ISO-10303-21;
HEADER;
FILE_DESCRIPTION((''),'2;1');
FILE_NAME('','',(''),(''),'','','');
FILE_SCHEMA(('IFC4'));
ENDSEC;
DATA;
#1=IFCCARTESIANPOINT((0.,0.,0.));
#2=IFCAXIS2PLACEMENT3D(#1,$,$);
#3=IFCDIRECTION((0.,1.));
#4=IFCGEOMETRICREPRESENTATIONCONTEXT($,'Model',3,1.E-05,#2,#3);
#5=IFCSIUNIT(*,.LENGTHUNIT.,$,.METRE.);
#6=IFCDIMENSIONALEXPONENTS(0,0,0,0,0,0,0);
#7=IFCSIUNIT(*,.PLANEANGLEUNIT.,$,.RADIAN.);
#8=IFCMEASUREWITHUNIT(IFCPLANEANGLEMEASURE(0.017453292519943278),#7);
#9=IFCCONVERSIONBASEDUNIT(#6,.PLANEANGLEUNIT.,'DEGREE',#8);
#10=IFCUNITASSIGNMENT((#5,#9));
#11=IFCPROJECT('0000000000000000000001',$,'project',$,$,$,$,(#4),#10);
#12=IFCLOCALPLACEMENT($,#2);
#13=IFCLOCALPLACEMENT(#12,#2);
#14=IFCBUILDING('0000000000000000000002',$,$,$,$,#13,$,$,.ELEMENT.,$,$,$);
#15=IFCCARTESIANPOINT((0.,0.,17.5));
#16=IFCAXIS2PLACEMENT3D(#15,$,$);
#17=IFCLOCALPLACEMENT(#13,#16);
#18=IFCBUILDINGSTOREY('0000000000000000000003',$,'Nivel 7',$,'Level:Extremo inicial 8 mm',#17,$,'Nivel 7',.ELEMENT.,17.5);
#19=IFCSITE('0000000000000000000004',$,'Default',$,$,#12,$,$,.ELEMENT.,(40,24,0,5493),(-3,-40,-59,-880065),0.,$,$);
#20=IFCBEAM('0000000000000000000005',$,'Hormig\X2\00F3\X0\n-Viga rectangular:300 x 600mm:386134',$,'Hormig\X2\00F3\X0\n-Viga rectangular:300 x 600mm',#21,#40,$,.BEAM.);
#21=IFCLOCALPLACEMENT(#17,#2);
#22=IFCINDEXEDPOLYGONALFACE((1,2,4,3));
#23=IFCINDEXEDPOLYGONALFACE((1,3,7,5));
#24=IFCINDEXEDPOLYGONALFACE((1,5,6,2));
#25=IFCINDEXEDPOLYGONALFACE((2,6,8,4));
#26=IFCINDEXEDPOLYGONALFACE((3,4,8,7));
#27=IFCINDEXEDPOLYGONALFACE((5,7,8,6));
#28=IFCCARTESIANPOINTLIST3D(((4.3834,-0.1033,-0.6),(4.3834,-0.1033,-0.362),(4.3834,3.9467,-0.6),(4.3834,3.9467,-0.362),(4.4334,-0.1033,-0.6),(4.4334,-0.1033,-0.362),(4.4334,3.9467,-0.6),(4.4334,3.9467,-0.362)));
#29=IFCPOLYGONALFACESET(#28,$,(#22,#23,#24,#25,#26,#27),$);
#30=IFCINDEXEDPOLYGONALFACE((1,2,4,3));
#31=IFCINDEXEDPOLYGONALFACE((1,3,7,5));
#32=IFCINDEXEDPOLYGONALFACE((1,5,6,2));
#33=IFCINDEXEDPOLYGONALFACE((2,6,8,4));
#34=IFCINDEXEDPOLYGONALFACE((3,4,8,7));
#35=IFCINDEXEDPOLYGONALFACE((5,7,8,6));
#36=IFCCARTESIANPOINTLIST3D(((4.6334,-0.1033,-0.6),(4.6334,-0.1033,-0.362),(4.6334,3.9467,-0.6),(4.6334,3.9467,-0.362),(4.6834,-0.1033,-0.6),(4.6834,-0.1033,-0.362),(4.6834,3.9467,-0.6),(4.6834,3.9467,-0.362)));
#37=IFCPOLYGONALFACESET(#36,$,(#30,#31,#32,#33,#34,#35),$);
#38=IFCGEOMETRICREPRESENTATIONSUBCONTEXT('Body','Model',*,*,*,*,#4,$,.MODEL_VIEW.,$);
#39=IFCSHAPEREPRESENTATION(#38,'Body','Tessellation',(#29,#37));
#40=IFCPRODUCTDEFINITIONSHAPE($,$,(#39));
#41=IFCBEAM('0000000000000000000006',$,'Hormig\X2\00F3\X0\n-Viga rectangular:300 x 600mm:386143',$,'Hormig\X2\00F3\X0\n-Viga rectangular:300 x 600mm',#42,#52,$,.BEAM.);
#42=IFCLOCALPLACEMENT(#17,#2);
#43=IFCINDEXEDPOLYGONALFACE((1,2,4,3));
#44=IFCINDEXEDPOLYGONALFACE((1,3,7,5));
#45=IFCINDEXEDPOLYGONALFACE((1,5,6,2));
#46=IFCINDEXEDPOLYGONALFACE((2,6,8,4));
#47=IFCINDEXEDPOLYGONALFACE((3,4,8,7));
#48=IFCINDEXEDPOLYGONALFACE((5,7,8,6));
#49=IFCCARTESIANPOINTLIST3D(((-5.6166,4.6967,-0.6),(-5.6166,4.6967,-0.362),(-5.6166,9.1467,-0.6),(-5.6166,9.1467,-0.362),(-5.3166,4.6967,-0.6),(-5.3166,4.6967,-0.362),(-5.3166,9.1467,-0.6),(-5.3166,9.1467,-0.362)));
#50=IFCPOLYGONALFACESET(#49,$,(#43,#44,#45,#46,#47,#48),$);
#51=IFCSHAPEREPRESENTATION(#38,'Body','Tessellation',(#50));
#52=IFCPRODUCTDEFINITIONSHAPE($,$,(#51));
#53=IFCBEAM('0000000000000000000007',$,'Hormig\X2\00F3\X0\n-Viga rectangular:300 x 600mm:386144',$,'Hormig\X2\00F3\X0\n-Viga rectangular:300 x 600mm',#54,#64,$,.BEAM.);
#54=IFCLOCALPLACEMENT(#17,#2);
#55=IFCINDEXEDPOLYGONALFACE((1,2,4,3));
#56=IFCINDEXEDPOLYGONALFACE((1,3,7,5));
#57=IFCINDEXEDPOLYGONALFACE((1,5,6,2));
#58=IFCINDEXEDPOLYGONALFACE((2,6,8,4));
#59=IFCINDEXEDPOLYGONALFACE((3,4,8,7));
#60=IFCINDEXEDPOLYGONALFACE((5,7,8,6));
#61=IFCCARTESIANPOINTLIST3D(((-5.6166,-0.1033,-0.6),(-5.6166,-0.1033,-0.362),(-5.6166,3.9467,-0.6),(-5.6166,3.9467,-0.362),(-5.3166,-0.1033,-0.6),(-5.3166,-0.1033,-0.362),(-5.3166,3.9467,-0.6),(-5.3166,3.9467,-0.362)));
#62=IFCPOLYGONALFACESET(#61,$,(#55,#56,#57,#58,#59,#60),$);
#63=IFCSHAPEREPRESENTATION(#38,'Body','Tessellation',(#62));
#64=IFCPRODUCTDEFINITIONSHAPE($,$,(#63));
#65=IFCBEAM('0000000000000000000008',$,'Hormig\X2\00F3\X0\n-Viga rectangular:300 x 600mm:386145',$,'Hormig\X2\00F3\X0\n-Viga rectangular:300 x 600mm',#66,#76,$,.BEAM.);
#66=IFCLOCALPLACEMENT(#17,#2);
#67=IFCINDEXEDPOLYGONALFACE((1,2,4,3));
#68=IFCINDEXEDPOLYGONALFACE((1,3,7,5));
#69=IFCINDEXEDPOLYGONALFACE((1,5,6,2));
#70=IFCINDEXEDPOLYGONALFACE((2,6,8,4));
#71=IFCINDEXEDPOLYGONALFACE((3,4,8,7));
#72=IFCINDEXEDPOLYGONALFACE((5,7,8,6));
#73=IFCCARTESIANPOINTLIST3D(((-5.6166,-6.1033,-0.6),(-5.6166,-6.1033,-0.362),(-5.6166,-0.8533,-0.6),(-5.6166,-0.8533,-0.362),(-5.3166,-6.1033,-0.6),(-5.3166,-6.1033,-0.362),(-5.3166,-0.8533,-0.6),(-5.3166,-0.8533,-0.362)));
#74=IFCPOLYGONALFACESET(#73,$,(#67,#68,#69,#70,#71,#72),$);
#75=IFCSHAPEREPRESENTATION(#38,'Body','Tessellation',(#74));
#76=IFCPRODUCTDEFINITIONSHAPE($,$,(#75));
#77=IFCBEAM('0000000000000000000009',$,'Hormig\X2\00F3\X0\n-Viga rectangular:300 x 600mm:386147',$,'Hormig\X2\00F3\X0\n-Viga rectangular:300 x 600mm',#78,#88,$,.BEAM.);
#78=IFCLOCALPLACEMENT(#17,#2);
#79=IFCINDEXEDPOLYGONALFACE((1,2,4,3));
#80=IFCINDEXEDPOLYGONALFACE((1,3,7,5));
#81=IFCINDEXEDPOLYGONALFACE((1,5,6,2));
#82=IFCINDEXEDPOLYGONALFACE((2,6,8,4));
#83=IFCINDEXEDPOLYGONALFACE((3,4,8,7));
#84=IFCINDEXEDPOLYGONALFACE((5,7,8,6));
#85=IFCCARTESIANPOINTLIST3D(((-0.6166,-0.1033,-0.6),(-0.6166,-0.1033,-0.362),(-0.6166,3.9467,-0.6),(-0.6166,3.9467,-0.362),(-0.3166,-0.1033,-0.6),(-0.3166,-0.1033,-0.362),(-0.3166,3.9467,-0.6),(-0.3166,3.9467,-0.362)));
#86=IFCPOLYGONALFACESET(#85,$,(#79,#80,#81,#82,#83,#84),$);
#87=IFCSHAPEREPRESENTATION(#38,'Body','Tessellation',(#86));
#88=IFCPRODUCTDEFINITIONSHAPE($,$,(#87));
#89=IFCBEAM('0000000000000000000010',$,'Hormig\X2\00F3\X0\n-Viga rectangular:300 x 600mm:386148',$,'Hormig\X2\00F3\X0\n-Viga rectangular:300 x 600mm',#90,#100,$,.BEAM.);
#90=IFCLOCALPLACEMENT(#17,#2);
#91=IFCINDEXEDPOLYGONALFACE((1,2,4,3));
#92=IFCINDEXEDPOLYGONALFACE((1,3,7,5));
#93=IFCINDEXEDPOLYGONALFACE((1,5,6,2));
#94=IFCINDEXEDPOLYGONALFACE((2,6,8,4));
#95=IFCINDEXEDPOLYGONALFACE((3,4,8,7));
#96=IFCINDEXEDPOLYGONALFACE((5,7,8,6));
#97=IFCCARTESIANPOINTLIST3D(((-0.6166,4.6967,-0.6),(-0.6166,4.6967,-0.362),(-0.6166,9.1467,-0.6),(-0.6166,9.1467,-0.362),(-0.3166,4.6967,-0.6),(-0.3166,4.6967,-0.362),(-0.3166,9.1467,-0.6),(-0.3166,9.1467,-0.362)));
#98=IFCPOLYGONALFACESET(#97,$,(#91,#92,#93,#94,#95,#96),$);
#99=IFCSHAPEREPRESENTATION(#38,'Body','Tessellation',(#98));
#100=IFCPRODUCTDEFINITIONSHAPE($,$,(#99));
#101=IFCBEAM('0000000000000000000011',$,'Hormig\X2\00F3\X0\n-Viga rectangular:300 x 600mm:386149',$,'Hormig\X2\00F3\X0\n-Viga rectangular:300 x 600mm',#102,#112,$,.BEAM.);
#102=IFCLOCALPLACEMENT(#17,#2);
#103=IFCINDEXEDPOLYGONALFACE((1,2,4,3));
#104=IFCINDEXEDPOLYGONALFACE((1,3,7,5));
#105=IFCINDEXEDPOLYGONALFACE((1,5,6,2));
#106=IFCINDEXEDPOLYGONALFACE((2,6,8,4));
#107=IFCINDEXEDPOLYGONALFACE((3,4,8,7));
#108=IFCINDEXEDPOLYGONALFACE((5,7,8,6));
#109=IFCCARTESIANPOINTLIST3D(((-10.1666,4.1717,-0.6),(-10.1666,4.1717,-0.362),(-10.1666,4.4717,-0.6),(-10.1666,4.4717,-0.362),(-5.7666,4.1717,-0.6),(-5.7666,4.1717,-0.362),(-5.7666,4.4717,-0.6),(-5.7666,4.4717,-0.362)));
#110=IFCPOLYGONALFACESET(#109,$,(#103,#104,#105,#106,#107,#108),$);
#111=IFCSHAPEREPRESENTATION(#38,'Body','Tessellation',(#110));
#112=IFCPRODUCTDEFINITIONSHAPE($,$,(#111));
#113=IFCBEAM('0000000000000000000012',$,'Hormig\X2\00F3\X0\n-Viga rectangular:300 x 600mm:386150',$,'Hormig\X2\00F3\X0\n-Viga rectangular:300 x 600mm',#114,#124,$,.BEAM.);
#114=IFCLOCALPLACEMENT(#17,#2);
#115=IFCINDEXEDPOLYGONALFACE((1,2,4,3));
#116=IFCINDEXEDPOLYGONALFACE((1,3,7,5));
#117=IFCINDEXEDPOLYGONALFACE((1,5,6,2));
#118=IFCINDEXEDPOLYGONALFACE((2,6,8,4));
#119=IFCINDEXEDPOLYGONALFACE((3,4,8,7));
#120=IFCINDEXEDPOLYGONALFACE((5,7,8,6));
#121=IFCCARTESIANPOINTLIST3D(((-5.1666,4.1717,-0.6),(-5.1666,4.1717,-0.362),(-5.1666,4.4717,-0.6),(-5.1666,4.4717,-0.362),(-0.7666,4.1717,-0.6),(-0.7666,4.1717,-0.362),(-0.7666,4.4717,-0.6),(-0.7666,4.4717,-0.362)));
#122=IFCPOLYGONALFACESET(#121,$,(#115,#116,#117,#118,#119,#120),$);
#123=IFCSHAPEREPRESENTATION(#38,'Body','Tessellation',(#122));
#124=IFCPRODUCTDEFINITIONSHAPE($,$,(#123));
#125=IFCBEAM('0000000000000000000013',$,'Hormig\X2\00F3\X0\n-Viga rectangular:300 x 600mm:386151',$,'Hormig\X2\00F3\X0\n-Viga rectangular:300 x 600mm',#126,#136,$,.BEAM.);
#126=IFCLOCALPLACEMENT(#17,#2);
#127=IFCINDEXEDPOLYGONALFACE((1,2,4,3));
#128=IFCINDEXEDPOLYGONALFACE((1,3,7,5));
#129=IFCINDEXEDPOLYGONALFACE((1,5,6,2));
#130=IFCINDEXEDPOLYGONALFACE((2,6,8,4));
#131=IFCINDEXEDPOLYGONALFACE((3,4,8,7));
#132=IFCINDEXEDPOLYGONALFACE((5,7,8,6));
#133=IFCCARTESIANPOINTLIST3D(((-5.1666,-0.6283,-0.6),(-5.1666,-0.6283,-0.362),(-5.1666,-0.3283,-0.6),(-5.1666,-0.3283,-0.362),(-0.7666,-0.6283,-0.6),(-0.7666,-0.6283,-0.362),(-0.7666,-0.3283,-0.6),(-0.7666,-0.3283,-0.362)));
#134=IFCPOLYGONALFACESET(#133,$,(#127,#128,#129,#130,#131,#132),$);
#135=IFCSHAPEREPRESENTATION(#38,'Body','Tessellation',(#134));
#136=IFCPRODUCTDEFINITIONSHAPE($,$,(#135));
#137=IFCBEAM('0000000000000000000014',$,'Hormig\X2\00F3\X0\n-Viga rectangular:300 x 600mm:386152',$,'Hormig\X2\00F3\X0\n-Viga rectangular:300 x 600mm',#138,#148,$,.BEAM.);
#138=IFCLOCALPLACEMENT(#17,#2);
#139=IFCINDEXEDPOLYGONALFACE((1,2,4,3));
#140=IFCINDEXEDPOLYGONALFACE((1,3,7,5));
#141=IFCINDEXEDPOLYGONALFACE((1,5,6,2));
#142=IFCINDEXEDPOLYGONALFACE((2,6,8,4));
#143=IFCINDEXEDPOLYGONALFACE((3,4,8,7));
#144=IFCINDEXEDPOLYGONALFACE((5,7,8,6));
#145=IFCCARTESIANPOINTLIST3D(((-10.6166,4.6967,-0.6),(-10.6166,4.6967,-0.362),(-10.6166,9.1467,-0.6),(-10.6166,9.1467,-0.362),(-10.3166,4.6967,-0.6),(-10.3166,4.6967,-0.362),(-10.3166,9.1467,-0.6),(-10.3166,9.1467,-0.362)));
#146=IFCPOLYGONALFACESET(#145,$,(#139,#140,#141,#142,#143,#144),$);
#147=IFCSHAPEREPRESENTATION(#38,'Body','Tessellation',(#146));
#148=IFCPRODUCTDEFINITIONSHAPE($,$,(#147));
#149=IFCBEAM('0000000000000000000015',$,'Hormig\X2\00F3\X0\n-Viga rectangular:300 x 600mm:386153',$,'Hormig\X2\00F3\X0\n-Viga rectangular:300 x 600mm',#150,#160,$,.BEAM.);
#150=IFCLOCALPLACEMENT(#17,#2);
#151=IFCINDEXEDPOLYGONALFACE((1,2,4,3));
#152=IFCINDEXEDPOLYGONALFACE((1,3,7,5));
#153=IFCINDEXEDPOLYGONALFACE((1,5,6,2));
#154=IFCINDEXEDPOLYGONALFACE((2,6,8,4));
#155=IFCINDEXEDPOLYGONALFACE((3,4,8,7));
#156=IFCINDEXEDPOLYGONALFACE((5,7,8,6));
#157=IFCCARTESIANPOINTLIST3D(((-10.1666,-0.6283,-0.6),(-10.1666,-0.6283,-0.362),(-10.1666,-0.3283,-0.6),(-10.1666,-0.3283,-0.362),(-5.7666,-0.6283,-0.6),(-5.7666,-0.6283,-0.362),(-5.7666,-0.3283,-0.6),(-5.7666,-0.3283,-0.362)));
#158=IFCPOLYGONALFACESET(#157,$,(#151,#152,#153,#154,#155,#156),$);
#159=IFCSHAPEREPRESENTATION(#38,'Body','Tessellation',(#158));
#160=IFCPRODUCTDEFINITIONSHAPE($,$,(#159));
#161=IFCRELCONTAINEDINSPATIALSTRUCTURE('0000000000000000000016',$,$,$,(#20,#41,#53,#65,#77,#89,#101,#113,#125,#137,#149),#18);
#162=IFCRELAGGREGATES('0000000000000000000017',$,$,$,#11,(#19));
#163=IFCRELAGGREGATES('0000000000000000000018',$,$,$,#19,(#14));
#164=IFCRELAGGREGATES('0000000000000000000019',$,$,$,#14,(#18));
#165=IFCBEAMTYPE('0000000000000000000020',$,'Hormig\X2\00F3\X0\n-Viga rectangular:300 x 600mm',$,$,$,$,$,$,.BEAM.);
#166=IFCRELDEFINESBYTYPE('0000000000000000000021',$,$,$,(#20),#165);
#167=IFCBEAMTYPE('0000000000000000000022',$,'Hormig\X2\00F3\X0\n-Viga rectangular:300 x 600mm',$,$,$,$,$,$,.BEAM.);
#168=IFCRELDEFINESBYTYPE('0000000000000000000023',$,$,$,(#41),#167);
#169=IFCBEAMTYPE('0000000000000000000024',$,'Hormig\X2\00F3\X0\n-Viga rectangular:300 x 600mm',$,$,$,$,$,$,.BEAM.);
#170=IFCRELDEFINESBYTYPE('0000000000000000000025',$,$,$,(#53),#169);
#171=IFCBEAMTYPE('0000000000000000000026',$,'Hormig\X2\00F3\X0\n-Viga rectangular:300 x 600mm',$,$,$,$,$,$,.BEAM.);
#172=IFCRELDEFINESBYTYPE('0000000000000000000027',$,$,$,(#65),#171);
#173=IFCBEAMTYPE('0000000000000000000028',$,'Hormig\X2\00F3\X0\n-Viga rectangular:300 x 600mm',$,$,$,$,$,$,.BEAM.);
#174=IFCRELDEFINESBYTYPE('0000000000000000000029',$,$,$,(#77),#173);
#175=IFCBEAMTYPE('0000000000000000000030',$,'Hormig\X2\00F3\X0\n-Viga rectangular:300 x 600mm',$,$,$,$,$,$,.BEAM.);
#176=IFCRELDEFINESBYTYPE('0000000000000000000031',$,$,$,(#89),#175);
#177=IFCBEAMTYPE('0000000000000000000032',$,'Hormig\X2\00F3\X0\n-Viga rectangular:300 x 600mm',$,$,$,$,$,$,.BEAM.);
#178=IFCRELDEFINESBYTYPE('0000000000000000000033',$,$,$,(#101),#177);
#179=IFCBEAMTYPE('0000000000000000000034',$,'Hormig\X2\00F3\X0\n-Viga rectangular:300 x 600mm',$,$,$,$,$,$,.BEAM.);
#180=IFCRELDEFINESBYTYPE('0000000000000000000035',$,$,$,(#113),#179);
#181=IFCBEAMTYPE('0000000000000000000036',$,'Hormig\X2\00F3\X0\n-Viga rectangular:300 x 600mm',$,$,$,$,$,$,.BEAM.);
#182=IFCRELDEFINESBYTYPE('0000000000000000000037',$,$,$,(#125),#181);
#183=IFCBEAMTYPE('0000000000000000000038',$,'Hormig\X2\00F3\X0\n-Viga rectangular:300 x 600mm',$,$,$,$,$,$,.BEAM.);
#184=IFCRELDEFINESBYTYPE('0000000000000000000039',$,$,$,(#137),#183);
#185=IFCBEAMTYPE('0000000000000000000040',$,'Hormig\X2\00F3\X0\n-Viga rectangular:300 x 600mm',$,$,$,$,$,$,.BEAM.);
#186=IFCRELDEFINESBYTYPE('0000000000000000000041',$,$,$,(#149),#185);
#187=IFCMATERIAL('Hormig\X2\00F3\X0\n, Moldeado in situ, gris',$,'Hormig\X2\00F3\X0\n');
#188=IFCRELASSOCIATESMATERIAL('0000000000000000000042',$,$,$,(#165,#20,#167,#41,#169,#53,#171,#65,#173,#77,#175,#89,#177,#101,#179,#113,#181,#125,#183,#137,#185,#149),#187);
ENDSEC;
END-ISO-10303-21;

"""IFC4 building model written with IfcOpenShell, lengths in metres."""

from ifc_helpers import new_model, entity, si_unit, converted_unit, direction, frame, origin, place, context, subcontext, project, spatial, indexed_curve, outline, extrude, source, transform, mapped, material, type_object, type_shapes, element, save


model = new_model("IFC4")

# Units and contexts
model_context = context("Model", 3, precision=1e-05, world=origin(), true_north=direction((0.0, 1.0)))
body_context = subcontext(model_context, "Body", "Model", "MODEL_VIEW")
ifc_project = project(units=[si_unit("LENGTHUNIT", "METRE"), converted_unit("PLANEANGLEUNIT", "DEGREE", entity("IfcPlaneAngleMeasure", 0.017453292519943278), si_unit("PLANEANGLEUNIT", "RADIAN"), dimensions=[0, 0, 0, 0, 0, 0, 0])], contexts=[model_context])

# Site, building, storey
site_placement = place(None, origin())
site = spatial("IfcSite", under=ifc_project, at=site_placement, Name="Default", CompositionType="ELEMENT", RefLatitude=(40, 24, 0, 5493), RefLongitude=(-3, -40, -59, -880065), RefElevation=0.0)
building_placement = place(site_placement, origin())
building = spatial("IfcBuilding", under=site, at=building_placement, CompositionType="ELEMENT")
storey_placement = place(building_placement, frame((0.0, 0.0, 17.5)))
storey = spatial("IfcBuildingStorey", under=building, at=storey_placement, Name="Nivel 7", ObjectType="Level:Extremo inicial 8 mm", LongName="Nivel 7", CompositionType="ELEMENT", Elevation=17.5)

# Shared definitions
ifc_material_1 = material(Name="Hormigón, Moldeado in situ, gris", Category="Hormigón")

# Beams
beam_type_1 = type_object("IfcBeamType", Name="Hormigón-Viga rectangular:300 x 600mm", PredefinedType="BEAM", material=ifc_material_1)
shared_shape_1 = source(origin(), body_context, "Body", "SweptSolid", [
    extrude(outline(indexed_curve([(-0.025, -0.119), (0.025, -0.119), (0.025, 0.119), (-0.025, 0.119), (-0.025, -0.119)], self_intersect=False)), frame((4.4084, 3.9467, 17.019), z_axis=(0.0, -1.0, 0.0), x_axis=(-1.0, 0.0, 0.0)), (0.0, 0.0, 1.0), 4.05),
    extrude(outline(indexed_curve([(-0.025, -0.119), (0.025, -0.119), (0.025, 0.119), (-0.025, 0.119), (-0.025, -0.119)], self_intersect=False)), frame((4.6584, 3.9467, 17.019), z_axis=(0.0, -1.0, 0.0), x_axis=(-1.0, 0.0, 0.0)), (0.0, 0.0, 1.0), 4.05),
])
type_shapes(beam_type_1, [shared_shape_1])
beam_1_placement = place(storey_placement, frame((0.0, 0.0, -17.5)))
element("IfcBeam", 1, at=beam_1_placement, inside=storey, type_object=beam_type_1, material=ifc_material_1, Name="Hormigón-Viga rectangular:300 x 600mm:386134", ObjectType="Hormigón-Viga rectangular:300 x 600mm", PredefinedType="BEAM", context=body_context, shape_type="MappedRepresentation", body=[
    mapped(shared_shape_1, transform((0.0, 0.0, 0.0), scale=1.0)),
])
beam_type_2 = type_object("IfcBeamType", Name="Hormigón-Viga rectangular:300 x 600mm", PredefinedType="BEAM", material=ifc_material_1)
shared_shape_2 = source(origin(), body_context, "Body", "SweptSolid", [
    extrude(outline(indexed_curve([(-0.15, -0.119), (0.15, -0.119), (0.15, 0.119), (-0.15, 0.119), (-0.15, -0.119)], self_intersect=False)), frame((-5.4666, 9.1467, 17.019), z_axis=(0.0, -1.0, 0.0), x_axis=(-1.0, 0.0, 0.0)), (0.0, 0.0, 1.0), 4.45),
])
type_shapes(beam_type_2, [shared_shape_2])
beam_2_placement = place(storey_placement, frame((0.0, 0.0, -17.5)))
element("IfcBeam", 2, at=beam_2_placement, inside=storey, type_object=beam_type_2, material=ifc_material_1, Name="Hormigón-Viga rectangular:300 x 600mm:386143", ObjectType="Hormigón-Viga rectangular:300 x 600mm", PredefinedType="BEAM", context=body_context, shape_type="MappedRepresentation", body=[
    mapped(shared_shape_2, transform((0.0, 0.0, 0.0), scale=1.0)),
])
beam_type_3 = type_object("IfcBeamType", Name="Hormigón-Viga rectangular:300 x 600mm", PredefinedType="BEAM", material=ifc_material_1)
shared_shape_3 = source(origin(), body_context, "Body", "SweptSolid", [
    extrude(outline(indexed_curve([(-0.15, -0.119), (0.15, -0.119), (0.15, 0.119), (-0.15, 0.119), (-0.15, -0.119)], self_intersect=False)), frame((-5.4666, 3.9467, 17.019), z_axis=(0.0, -1.0, 0.0), x_axis=(-1.0, 0.0, 0.0)), (0.0, 0.0, 1.0), 4.05),
])
type_shapes(beam_type_3, [shared_shape_3])
beam_3_placement = place(storey_placement, frame((0.0, 0.0, -17.5)))
element("IfcBeam", 3, at=beam_3_placement, inside=storey, type_object=beam_type_3, material=ifc_material_1, Name="Hormigón-Viga rectangular:300 x 600mm:386144", ObjectType="Hormigón-Viga rectangular:300 x 600mm", PredefinedType="BEAM", context=body_context, shape_type="MappedRepresentation", body=[
    mapped(shared_shape_3, transform((0.0, 0.0, 0.0), scale=1.0)),
])
beam_type_4 = type_object("IfcBeamType", Name="Hormigón-Viga rectangular:300 x 600mm", PredefinedType="BEAM", material=ifc_material_1)
shared_shape_4 = source(origin(), body_context, "Body", "SweptSolid", [
    extrude(outline(indexed_curve([(-0.15, -0.119), (0.15, -0.119), (0.15, 0.119), (-0.15, 0.119), (-0.15, -0.119)], self_intersect=False)), frame((-5.4666, -6.1033, 17.019), z_axis=(0.0, 1.0, 0.0), x_axis=(-1.0, 0.0, 0.0)), (0.0, 0.0, 1.0), 5.25),
])
type_shapes(beam_type_4, [shared_shape_4])
beam_4_placement = place(storey_placement, frame((0.0, 0.0, -17.5)))
element("IfcBeam", 4, at=beam_4_placement, inside=storey, type_object=beam_type_4, material=ifc_material_1, Name="Hormigón-Viga rectangular:300 x 600mm:386145", ObjectType="Hormigón-Viga rectangular:300 x 600mm", PredefinedType="BEAM", context=body_context, shape_type="MappedRepresentation", body=[
    mapped(shared_shape_4, transform((0.0, 0.0, 0.0), scale=1.0)),
])
beam_type_5 = type_object("IfcBeamType", Name="Hormigón-Viga rectangular:300 x 600mm", PredefinedType="BEAM", material=ifc_material_1)
shared_shape_5 = source(origin(), body_context, "Body", "SweptSolid", [
    extrude(outline(indexed_curve([(-0.15, -0.119), (0.15, -0.119), (0.15, 0.119), (-0.15, 0.119), (-0.15, -0.119)], self_intersect=False)), frame((-0.4666, -0.1033, 17.019), z_axis=(0.0, 1.0, 0.0), x_axis=(-1.0, 0.0, 0.0)), (0.0, 0.0, 1.0), 4.05),
])
type_shapes(beam_type_5, [shared_shape_5])
beam_5_placement = place(storey_placement, frame((0.0, 0.0, -17.5)))
element("IfcBeam", 5, at=beam_5_placement, inside=storey, type_object=beam_type_5, material=ifc_material_1, Name="Hormigón-Viga rectangular:300 x 600mm:386147", ObjectType="Hormigón-Viga rectangular:300 x 600mm", PredefinedType="BEAM", context=body_context, shape_type="MappedRepresentation", body=[
    mapped(shared_shape_5, transform((0.0, 0.0, 0.0), scale=1.0)),
])
beam_type_6 = type_object("IfcBeamType", Name="Hormigón-Viga rectangular:300 x 600mm", PredefinedType="BEAM", material=ifc_material_1)
shared_shape_6 = source(origin(), body_context, "Body", "SweptSolid", [
    extrude(outline(indexed_curve([(-0.15, -0.119), (0.15, -0.119), (0.15, 0.119), (-0.15, 0.119), (-0.15, -0.119)], self_intersect=False)), frame((-0.4666, 9.1467, 17.019), z_axis=(0.0, -1.0, 0.0), x_axis=(-1.0, 0.0, 0.0)), (0.0, 0.0, 1.0), 4.45),
])
type_shapes(beam_type_6, [shared_shape_6])
beam_6_placement = place(storey_placement, frame((0.0, 0.0, -17.5)))
element("IfcBeam", 6, at=beam_6_placement, inside=storey, type_object=beam_type_6, material=ifc_material_1, Name="Hormigón-Viga rectangular:300 x 600mm:386148", ObjectType="Hormigón-Viga rectangular:300 x 600mm", PredefinedType="BEAM", context=body_context, shape_type="MappedRepresentation", body=[
    mapped(shared_shape_6, transform((0.0, 0.0, 0.0), scale=1.0)),
])
beam_type_7 = type_object("IfcBeamType", Name="Hormigón-Viga rectangular:300 x 600mm", PredefinedType="BEAM", material=ifc_material_1)
shared_shape_7 = source(origin(), body_context, "Body", "SweptSolid", [
    extrude(outline(indexed_curve([(-0.119, -0.15), (0.119, -0.15), (0.119, 0.15), (-0.119, 0.15), (-0.119, -0.15)], self_intersect=False)), frame((-10.1666, 4.3217, 17.019), z_axis=(1.0, 0.0, 0.0), x_axis=(0.0, 0.0, -1.0)), (0.0, 0.0, 1.0), 4.4),
])
type_shapes(beam_type_7, [shared_shape_7])
beam_7_placement = place(storey_placement, frame((0.0, 0.0, -17.5)))
element("IfcBeam", 7, at=beam_7_placement, inside=storey, type_object=beam_type_7, material=ifc_material_1, Name="Hormigón-Viga rectangular:300 x 600mm:386149", ObjectType="Hormigón-Viga rectangular:300 x 600mm", PredefinedType="BEAM", context=body_context, shape_type="MappedRepresentation", body=[
    mapped(shared_shape_7, transform((0.0, 0.0, 0.0), scale=1.0)),
])
beam_type_8 = type_object("IfcBeamType", Name="Hormigón-Viga rectangular:300 x 600mm", PredefinedType="BEAM", material=ifc_material_1)
shared_shape_8 = source(origin(), body_context, "Body", "SweptSolid", [
    extrude(outline(indexed_curve([(-0.119, -0.15), (0.119, -0.15), (0.119, 0.15), (-0.119, 0.15), (-0.119, -0.15)], self_intersect=False)), frame((-5.1666, 4.3217, 17.019), z_axis=(1.0, 0.0, 0.0), x_axis=(0.0, 0.0, -1.0)), (0.0, 0.0, 1.0), 4.4),
])
type_shapes(beam_type_8, [shared_shape_8])
beam_8_placement = place(storey_placement, frame((0.0, 0.0, -17.5)))
element("IfcBeam", 8, at=beam_8_placement, inside=storey, type_object=beam_type_8, material=ifc_material_1, Name="Hormigón-Viga rectangular:300 x 600mm:386150", ObjectType="Hormigón-Viga rectangular:300 x 600mm", PredefinedType="BEAM", context=body_context, shape_type="MappedRepresentation", body=[
    mapped(shared_shape_8, transform((0.0, 0.0, 0.0), scale=1.0)),
])
beam_type_9 = type_object("IfcBeamType", Name="Hormigón-Viga rectangular:300 x 600mm", PredefinedType="BEAM", material=ifc_material_1)
shared_shape_9 = source(origin(), body_context, "Body", "SweptSolid", [
    extrude(outline(indexed_curve([(-0.119, -0.15), (0.119, -0.15), (0.119, 0.15), (-0.119, 0.15), (-0.119, -0.15)], self_intersect=False)), frame((-0.7666, -0.4783, 17.019), z_axis=(-1.0, 0.0, 0.0), x_axis=(0.0, 0.0, -1.0)), (0.0, 0.0, 1.0), 4.4),
])
type_shapes(beam_type_9, [shared_shape_9])
beam_9_placement = place(storey_placement, frame((0.0, 0.0, -17.5)))
element("IfcBeam", 9, at=beam_9_placement, inside=storey, type_object=beam_type_9, material=ifc_material_1, Name="Hormigón-Viga rectangular:300 x 600mm:386151", ObjectType="Hormigón-Viga rectangular:300 x 600mm", PredefinedType="BEAM", context=body_context, shape_type="MappedRepresentation", body=[
    mapped(shared_shape_9, transform((0.0, 0.0, 0.0), scale=1.0)),
])
beam_type_10 = type_object("IfcBeamType", Name="Hormigón-Viga rectangular:300 x 600mm", PredefinedType="BEAM", material=ifc_material_1)
shared_shape_10 = source(origin(), body_context, "Body", "SweptSolid", [
    extrude(outline(indexed_curve([(-0.15, -0.119), (0.15, -0.119), (0.15, 0.119), (-0.15, 0.119), (-0.15, -0.119)], self_intersect=False)), frame((-10.4666, 4.6967, 17.019), z_axis=(0.0, 1.0, 0.0), x_axis=(-1.0, 0.0, 0.0)), (0.0, 0.0, 1.0), 4.45),
])
type_shapes(beam_type_10, [shared_shape_10])
beam_10_placement = place(storey_placement, frame((0.0, 0.0, -17.5)))
element("IfcBeam", 10, at=beam_10_placement, inside=storey, type_object=beam_type_10, material=ifc_material_1, Name="Hormigón-Viga rectangular:300 x 600mm:386152", ObjectType="Hormigón-Viga rectangular:300 x 600mm", PredefinedType="BEAM", context=body_context, shape_type="MappedRepresentation", body=[
    mapped(shared_shape_10, transform((0.0, 0.0, 0.0), scale=1.0)),
])
beam_type_11 = type_object("IfcBeamType", Name="Hormigón-Viga rectangular:300 x 600mm", PredefinedType="BEAM", material=ifc_material_1)
shared_shape_11 = source(origin(), body_context, "Body", "SweptSolid", [
    extrude(outline(indexed_curve([(-0.119, -0.15), (0.119, -0.15), (0.119, 0.15), (-0.119, 0.15), (-0.119, -0.15)], self_intersect=False)), frame((-10.1666, -0.4783, 17.019), z_axis=(1.0, 0.0, 0.0), x_axis=(0.0, 0.0, -1.0)), (0.0, 0.0, 1.0), 4.4),
])
type_shapes(beam_type_11, [shared_shape_11])
beam_11_placement = place(storey_placement, frame((0.0, 0.0, -17.5)))
element("IfcBeam", 11, at=beam_11_placement, inside=storey, type_object=beam_type_11, material=ifc_material_1, Name="Hormigón-Viga rectangular:300 x 600mm:386153", ObjectType="Hormigón-Viga rectangular:300 x 600mm", PredefinedType="BEAM", context=body_context, shape_type="MappedRepresentation", body=[
    mapped(shared_shape_11, transform((0.0, 0.0, 0.0), scale=1.0)),
])

save(model, "model.ifc")
